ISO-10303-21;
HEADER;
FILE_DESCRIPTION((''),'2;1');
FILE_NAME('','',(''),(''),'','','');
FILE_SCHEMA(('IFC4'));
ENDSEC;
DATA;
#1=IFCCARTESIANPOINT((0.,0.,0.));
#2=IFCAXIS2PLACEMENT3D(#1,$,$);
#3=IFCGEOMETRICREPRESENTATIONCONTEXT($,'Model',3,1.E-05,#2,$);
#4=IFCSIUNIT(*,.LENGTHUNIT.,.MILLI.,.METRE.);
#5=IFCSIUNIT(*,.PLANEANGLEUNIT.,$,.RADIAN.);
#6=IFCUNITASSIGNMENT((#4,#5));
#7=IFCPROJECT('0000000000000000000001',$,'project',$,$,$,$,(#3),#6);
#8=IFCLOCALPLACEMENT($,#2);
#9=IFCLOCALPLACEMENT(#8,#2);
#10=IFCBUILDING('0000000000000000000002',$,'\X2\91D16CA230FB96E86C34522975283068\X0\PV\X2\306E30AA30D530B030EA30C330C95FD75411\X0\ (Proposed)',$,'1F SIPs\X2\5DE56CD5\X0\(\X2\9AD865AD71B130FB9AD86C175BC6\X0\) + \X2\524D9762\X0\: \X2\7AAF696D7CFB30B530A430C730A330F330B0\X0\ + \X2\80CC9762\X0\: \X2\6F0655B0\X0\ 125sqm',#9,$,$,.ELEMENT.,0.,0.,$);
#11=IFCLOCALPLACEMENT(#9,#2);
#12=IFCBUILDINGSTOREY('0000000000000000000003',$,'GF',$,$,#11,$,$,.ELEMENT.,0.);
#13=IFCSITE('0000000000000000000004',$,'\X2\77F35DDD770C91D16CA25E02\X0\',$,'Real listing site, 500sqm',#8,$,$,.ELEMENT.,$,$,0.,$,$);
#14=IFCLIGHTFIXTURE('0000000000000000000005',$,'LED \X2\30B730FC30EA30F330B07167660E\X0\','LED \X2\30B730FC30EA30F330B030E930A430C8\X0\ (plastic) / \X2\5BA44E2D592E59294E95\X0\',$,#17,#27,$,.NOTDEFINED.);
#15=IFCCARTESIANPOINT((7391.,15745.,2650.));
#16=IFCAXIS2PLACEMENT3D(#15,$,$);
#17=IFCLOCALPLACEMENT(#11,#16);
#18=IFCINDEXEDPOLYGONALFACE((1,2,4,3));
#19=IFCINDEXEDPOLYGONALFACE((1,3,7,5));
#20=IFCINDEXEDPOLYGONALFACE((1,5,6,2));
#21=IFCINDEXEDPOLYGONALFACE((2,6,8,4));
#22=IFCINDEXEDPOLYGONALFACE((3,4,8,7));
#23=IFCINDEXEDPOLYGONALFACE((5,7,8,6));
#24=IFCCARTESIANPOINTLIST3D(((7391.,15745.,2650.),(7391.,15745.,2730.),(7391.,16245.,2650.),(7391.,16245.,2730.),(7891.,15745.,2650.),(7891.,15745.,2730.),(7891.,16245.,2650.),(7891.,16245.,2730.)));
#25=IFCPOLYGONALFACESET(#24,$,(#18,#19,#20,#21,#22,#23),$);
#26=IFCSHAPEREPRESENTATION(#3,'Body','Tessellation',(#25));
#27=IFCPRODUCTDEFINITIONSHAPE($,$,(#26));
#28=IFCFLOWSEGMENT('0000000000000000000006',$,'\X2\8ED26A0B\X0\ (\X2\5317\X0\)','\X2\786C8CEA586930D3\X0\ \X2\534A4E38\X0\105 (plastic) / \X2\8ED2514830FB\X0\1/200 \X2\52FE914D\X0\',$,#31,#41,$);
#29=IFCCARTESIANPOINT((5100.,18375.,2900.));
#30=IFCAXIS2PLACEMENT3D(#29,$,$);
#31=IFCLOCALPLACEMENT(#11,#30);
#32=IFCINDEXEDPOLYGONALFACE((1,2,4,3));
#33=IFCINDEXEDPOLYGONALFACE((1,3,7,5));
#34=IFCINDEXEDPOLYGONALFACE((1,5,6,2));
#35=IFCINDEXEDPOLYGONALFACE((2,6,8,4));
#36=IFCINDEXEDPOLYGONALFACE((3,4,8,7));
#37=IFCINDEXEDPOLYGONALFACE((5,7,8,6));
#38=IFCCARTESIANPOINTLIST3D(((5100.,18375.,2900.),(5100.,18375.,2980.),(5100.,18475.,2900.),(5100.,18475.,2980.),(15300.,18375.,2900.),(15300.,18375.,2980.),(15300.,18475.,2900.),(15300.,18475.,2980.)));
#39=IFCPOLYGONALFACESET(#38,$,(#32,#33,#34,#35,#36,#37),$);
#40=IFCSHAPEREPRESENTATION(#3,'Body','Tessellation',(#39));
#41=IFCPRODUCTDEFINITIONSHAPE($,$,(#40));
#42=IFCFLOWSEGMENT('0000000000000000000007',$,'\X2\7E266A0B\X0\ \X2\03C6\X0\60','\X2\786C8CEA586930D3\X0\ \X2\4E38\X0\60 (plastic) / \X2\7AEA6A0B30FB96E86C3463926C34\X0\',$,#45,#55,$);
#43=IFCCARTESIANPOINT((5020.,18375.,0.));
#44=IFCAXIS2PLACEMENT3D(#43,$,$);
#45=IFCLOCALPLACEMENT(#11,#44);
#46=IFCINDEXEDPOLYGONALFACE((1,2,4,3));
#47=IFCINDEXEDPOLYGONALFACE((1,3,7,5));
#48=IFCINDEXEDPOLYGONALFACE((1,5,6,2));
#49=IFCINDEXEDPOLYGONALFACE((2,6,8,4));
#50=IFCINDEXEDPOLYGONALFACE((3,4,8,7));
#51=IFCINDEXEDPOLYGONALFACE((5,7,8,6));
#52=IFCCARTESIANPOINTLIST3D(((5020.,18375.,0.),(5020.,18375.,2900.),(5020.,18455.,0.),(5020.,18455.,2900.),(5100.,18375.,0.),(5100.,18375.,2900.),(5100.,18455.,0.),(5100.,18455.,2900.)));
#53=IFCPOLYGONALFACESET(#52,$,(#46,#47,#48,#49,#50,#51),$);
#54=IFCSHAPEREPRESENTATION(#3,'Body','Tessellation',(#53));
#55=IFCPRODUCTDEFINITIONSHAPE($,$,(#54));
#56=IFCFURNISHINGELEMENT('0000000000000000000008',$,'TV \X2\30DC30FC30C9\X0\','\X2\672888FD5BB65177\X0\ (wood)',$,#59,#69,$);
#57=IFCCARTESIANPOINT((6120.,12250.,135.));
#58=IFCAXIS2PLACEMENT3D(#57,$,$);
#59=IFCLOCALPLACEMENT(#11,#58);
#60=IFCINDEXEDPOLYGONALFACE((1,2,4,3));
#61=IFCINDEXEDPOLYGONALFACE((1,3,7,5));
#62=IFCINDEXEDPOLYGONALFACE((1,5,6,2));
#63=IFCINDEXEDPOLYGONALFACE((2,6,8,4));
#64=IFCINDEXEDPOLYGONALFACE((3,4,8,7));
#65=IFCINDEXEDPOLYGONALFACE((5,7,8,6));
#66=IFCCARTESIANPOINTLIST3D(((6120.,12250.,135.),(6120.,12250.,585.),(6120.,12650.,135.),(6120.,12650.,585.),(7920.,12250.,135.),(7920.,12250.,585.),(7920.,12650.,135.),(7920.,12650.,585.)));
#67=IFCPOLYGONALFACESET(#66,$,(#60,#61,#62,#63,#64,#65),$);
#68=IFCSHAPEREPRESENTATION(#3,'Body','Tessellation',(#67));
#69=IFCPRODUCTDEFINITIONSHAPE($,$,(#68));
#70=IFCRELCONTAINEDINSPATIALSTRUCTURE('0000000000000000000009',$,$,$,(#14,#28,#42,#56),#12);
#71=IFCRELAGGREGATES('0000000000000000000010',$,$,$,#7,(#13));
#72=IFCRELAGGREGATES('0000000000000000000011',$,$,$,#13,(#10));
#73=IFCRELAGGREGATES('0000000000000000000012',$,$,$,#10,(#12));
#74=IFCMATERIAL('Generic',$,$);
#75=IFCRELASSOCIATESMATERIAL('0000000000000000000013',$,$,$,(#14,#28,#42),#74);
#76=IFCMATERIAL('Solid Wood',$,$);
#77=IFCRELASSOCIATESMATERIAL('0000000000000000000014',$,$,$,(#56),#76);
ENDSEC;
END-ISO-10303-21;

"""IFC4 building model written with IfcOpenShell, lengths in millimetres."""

from ifc_helpers import new_model, si_unit, frame, frame_2d, origin, place, context, project, spatial, rectangle, extrude, material, element, save


model = new_model("IFC4")

# Units and contexts
model_context = context("Model", 3, precision=1e-05, world=origin())
ifc_project = project(units=[si_unit("LENGTHUNIT", "METRE", prefix="MILLI"), si_unit("PLANEANGLEUNIT", "RADIAN")], contexts=[model_context])

# Site, building, storey
site_placement = place(None, origin())
site = spatial("IfcSite", under=ifc_project, at=site_placement, Name="石川県金沢市", ObjectType="Real listing site, 500sqm", CompositionType="ELEMENT", RefElevation=0.0)
building_placement = place(site_placement, origin())
building = spatial("IfcBuilding", under=site, at=building_placement, Name="金沢・雨水利用とPVのオフグリッド志向 (Proposed)", ObjectType="1F SIPs工法(高断熱・高気密) + 前面: 窯業系サイディング + 背面: 漆喰 125sqm", CompositionType="ELEMENT", ElevationOfRefHeight=0.0, ElevationOfTerrain=0.0)
storey_placement = place(building_placement, origin())
storey = spatial("IfcBuildingStorey", under=building, at=storey_placement, Name="GF", CompositionType="ELEMENT", Elevation=0.0)

# Shared definitions
ifc_material_1 = material(Name="Solid Wood")

# Shared definitions
ifc_material_2 = material(Name="Generic")

# Light fixture
light_fixture_placement = place(storey_placement, frame((7391.0, 15745.0, 2650.0)))
element("IfcLightFixture", 1, at=light_fixture_placement, inside=storey, material=ifc_material_2, Name="LED シーリング照明", Description="LED シーリングライト (plastic) / 室中央天井", PredefinedType="NOTDEFINED", context=model_context, shape_type="SweptSolid", body=[
    extrude(rectangle(XDim=500.0, YDim=500.0, at=frame_2d((250.0, 250.0))), frame((7391.0, 15745.0, 2650.0)), (0.0, 0.0, 1.0), 80.0),
])

# Flow segments
flow_segment_1_placement = place(storey_placement, frame((5100.0, 18375.0, 2900.0)))
element("IfcFlowSegment", 2, at=flow_segment_1_placement, inside=storey, material=ifc_material_2, Name="軒樋 (北)", Description="硬質塩ビ 半丸105 (plastic) / 軒先・1/200 勾配", context=model_context, shape_type="SweptSolid", body=[
    extrude(rectangle(XDim=10200.0, YDim=100.0, at=frame_2d((5100.0, 50.0))), frame((5100.0, 18375.0, 2900.0)), (0.0, 0.0, 1.0), 80.0),
])
flow_segment_2_placement = place(storey_placement, frame((5020.0, 18375.0, 0.0)))
element("IfcFlowSegment", 3, at=flow_segment_2_placement, inside=storey, material=ifc_material_2, Name="縦樋 φ60", Description="硬質塩ビ 丸60 (plastic) / 竪樋・雨水排水", context=model_context, shape_type="SweptSolid", body=[
    extrude(rectangle(XDim=80.0, YDim=80.0, at=frame_2d((40.0, 40.0))), frame((5020.0, 18375.0, 0.0)), (0.0, 0.0, 1.0), 2900.0),
])

# Furnishing element
furnishing_placement = place(storey_placement, frame((6120.0, 12250.0, 135.0)))
element("IfcFurnishingElement", 4, at=furnishing_placement, inside=storey, material=ifc_material_1, Name="TV ボード", Description="木製家具 (wood)", context=model_context, shape_type="SweptSolid", body=[
    extrude(rectangle(XDim=1800.0, YDim=400.0, at=frame_2d((900.0, 200.0))), frame((6120.0, 12250.0, 135.0)), (0.0, 0.0, 1.0), 450.0),
])

save(model, "model.ifc")
